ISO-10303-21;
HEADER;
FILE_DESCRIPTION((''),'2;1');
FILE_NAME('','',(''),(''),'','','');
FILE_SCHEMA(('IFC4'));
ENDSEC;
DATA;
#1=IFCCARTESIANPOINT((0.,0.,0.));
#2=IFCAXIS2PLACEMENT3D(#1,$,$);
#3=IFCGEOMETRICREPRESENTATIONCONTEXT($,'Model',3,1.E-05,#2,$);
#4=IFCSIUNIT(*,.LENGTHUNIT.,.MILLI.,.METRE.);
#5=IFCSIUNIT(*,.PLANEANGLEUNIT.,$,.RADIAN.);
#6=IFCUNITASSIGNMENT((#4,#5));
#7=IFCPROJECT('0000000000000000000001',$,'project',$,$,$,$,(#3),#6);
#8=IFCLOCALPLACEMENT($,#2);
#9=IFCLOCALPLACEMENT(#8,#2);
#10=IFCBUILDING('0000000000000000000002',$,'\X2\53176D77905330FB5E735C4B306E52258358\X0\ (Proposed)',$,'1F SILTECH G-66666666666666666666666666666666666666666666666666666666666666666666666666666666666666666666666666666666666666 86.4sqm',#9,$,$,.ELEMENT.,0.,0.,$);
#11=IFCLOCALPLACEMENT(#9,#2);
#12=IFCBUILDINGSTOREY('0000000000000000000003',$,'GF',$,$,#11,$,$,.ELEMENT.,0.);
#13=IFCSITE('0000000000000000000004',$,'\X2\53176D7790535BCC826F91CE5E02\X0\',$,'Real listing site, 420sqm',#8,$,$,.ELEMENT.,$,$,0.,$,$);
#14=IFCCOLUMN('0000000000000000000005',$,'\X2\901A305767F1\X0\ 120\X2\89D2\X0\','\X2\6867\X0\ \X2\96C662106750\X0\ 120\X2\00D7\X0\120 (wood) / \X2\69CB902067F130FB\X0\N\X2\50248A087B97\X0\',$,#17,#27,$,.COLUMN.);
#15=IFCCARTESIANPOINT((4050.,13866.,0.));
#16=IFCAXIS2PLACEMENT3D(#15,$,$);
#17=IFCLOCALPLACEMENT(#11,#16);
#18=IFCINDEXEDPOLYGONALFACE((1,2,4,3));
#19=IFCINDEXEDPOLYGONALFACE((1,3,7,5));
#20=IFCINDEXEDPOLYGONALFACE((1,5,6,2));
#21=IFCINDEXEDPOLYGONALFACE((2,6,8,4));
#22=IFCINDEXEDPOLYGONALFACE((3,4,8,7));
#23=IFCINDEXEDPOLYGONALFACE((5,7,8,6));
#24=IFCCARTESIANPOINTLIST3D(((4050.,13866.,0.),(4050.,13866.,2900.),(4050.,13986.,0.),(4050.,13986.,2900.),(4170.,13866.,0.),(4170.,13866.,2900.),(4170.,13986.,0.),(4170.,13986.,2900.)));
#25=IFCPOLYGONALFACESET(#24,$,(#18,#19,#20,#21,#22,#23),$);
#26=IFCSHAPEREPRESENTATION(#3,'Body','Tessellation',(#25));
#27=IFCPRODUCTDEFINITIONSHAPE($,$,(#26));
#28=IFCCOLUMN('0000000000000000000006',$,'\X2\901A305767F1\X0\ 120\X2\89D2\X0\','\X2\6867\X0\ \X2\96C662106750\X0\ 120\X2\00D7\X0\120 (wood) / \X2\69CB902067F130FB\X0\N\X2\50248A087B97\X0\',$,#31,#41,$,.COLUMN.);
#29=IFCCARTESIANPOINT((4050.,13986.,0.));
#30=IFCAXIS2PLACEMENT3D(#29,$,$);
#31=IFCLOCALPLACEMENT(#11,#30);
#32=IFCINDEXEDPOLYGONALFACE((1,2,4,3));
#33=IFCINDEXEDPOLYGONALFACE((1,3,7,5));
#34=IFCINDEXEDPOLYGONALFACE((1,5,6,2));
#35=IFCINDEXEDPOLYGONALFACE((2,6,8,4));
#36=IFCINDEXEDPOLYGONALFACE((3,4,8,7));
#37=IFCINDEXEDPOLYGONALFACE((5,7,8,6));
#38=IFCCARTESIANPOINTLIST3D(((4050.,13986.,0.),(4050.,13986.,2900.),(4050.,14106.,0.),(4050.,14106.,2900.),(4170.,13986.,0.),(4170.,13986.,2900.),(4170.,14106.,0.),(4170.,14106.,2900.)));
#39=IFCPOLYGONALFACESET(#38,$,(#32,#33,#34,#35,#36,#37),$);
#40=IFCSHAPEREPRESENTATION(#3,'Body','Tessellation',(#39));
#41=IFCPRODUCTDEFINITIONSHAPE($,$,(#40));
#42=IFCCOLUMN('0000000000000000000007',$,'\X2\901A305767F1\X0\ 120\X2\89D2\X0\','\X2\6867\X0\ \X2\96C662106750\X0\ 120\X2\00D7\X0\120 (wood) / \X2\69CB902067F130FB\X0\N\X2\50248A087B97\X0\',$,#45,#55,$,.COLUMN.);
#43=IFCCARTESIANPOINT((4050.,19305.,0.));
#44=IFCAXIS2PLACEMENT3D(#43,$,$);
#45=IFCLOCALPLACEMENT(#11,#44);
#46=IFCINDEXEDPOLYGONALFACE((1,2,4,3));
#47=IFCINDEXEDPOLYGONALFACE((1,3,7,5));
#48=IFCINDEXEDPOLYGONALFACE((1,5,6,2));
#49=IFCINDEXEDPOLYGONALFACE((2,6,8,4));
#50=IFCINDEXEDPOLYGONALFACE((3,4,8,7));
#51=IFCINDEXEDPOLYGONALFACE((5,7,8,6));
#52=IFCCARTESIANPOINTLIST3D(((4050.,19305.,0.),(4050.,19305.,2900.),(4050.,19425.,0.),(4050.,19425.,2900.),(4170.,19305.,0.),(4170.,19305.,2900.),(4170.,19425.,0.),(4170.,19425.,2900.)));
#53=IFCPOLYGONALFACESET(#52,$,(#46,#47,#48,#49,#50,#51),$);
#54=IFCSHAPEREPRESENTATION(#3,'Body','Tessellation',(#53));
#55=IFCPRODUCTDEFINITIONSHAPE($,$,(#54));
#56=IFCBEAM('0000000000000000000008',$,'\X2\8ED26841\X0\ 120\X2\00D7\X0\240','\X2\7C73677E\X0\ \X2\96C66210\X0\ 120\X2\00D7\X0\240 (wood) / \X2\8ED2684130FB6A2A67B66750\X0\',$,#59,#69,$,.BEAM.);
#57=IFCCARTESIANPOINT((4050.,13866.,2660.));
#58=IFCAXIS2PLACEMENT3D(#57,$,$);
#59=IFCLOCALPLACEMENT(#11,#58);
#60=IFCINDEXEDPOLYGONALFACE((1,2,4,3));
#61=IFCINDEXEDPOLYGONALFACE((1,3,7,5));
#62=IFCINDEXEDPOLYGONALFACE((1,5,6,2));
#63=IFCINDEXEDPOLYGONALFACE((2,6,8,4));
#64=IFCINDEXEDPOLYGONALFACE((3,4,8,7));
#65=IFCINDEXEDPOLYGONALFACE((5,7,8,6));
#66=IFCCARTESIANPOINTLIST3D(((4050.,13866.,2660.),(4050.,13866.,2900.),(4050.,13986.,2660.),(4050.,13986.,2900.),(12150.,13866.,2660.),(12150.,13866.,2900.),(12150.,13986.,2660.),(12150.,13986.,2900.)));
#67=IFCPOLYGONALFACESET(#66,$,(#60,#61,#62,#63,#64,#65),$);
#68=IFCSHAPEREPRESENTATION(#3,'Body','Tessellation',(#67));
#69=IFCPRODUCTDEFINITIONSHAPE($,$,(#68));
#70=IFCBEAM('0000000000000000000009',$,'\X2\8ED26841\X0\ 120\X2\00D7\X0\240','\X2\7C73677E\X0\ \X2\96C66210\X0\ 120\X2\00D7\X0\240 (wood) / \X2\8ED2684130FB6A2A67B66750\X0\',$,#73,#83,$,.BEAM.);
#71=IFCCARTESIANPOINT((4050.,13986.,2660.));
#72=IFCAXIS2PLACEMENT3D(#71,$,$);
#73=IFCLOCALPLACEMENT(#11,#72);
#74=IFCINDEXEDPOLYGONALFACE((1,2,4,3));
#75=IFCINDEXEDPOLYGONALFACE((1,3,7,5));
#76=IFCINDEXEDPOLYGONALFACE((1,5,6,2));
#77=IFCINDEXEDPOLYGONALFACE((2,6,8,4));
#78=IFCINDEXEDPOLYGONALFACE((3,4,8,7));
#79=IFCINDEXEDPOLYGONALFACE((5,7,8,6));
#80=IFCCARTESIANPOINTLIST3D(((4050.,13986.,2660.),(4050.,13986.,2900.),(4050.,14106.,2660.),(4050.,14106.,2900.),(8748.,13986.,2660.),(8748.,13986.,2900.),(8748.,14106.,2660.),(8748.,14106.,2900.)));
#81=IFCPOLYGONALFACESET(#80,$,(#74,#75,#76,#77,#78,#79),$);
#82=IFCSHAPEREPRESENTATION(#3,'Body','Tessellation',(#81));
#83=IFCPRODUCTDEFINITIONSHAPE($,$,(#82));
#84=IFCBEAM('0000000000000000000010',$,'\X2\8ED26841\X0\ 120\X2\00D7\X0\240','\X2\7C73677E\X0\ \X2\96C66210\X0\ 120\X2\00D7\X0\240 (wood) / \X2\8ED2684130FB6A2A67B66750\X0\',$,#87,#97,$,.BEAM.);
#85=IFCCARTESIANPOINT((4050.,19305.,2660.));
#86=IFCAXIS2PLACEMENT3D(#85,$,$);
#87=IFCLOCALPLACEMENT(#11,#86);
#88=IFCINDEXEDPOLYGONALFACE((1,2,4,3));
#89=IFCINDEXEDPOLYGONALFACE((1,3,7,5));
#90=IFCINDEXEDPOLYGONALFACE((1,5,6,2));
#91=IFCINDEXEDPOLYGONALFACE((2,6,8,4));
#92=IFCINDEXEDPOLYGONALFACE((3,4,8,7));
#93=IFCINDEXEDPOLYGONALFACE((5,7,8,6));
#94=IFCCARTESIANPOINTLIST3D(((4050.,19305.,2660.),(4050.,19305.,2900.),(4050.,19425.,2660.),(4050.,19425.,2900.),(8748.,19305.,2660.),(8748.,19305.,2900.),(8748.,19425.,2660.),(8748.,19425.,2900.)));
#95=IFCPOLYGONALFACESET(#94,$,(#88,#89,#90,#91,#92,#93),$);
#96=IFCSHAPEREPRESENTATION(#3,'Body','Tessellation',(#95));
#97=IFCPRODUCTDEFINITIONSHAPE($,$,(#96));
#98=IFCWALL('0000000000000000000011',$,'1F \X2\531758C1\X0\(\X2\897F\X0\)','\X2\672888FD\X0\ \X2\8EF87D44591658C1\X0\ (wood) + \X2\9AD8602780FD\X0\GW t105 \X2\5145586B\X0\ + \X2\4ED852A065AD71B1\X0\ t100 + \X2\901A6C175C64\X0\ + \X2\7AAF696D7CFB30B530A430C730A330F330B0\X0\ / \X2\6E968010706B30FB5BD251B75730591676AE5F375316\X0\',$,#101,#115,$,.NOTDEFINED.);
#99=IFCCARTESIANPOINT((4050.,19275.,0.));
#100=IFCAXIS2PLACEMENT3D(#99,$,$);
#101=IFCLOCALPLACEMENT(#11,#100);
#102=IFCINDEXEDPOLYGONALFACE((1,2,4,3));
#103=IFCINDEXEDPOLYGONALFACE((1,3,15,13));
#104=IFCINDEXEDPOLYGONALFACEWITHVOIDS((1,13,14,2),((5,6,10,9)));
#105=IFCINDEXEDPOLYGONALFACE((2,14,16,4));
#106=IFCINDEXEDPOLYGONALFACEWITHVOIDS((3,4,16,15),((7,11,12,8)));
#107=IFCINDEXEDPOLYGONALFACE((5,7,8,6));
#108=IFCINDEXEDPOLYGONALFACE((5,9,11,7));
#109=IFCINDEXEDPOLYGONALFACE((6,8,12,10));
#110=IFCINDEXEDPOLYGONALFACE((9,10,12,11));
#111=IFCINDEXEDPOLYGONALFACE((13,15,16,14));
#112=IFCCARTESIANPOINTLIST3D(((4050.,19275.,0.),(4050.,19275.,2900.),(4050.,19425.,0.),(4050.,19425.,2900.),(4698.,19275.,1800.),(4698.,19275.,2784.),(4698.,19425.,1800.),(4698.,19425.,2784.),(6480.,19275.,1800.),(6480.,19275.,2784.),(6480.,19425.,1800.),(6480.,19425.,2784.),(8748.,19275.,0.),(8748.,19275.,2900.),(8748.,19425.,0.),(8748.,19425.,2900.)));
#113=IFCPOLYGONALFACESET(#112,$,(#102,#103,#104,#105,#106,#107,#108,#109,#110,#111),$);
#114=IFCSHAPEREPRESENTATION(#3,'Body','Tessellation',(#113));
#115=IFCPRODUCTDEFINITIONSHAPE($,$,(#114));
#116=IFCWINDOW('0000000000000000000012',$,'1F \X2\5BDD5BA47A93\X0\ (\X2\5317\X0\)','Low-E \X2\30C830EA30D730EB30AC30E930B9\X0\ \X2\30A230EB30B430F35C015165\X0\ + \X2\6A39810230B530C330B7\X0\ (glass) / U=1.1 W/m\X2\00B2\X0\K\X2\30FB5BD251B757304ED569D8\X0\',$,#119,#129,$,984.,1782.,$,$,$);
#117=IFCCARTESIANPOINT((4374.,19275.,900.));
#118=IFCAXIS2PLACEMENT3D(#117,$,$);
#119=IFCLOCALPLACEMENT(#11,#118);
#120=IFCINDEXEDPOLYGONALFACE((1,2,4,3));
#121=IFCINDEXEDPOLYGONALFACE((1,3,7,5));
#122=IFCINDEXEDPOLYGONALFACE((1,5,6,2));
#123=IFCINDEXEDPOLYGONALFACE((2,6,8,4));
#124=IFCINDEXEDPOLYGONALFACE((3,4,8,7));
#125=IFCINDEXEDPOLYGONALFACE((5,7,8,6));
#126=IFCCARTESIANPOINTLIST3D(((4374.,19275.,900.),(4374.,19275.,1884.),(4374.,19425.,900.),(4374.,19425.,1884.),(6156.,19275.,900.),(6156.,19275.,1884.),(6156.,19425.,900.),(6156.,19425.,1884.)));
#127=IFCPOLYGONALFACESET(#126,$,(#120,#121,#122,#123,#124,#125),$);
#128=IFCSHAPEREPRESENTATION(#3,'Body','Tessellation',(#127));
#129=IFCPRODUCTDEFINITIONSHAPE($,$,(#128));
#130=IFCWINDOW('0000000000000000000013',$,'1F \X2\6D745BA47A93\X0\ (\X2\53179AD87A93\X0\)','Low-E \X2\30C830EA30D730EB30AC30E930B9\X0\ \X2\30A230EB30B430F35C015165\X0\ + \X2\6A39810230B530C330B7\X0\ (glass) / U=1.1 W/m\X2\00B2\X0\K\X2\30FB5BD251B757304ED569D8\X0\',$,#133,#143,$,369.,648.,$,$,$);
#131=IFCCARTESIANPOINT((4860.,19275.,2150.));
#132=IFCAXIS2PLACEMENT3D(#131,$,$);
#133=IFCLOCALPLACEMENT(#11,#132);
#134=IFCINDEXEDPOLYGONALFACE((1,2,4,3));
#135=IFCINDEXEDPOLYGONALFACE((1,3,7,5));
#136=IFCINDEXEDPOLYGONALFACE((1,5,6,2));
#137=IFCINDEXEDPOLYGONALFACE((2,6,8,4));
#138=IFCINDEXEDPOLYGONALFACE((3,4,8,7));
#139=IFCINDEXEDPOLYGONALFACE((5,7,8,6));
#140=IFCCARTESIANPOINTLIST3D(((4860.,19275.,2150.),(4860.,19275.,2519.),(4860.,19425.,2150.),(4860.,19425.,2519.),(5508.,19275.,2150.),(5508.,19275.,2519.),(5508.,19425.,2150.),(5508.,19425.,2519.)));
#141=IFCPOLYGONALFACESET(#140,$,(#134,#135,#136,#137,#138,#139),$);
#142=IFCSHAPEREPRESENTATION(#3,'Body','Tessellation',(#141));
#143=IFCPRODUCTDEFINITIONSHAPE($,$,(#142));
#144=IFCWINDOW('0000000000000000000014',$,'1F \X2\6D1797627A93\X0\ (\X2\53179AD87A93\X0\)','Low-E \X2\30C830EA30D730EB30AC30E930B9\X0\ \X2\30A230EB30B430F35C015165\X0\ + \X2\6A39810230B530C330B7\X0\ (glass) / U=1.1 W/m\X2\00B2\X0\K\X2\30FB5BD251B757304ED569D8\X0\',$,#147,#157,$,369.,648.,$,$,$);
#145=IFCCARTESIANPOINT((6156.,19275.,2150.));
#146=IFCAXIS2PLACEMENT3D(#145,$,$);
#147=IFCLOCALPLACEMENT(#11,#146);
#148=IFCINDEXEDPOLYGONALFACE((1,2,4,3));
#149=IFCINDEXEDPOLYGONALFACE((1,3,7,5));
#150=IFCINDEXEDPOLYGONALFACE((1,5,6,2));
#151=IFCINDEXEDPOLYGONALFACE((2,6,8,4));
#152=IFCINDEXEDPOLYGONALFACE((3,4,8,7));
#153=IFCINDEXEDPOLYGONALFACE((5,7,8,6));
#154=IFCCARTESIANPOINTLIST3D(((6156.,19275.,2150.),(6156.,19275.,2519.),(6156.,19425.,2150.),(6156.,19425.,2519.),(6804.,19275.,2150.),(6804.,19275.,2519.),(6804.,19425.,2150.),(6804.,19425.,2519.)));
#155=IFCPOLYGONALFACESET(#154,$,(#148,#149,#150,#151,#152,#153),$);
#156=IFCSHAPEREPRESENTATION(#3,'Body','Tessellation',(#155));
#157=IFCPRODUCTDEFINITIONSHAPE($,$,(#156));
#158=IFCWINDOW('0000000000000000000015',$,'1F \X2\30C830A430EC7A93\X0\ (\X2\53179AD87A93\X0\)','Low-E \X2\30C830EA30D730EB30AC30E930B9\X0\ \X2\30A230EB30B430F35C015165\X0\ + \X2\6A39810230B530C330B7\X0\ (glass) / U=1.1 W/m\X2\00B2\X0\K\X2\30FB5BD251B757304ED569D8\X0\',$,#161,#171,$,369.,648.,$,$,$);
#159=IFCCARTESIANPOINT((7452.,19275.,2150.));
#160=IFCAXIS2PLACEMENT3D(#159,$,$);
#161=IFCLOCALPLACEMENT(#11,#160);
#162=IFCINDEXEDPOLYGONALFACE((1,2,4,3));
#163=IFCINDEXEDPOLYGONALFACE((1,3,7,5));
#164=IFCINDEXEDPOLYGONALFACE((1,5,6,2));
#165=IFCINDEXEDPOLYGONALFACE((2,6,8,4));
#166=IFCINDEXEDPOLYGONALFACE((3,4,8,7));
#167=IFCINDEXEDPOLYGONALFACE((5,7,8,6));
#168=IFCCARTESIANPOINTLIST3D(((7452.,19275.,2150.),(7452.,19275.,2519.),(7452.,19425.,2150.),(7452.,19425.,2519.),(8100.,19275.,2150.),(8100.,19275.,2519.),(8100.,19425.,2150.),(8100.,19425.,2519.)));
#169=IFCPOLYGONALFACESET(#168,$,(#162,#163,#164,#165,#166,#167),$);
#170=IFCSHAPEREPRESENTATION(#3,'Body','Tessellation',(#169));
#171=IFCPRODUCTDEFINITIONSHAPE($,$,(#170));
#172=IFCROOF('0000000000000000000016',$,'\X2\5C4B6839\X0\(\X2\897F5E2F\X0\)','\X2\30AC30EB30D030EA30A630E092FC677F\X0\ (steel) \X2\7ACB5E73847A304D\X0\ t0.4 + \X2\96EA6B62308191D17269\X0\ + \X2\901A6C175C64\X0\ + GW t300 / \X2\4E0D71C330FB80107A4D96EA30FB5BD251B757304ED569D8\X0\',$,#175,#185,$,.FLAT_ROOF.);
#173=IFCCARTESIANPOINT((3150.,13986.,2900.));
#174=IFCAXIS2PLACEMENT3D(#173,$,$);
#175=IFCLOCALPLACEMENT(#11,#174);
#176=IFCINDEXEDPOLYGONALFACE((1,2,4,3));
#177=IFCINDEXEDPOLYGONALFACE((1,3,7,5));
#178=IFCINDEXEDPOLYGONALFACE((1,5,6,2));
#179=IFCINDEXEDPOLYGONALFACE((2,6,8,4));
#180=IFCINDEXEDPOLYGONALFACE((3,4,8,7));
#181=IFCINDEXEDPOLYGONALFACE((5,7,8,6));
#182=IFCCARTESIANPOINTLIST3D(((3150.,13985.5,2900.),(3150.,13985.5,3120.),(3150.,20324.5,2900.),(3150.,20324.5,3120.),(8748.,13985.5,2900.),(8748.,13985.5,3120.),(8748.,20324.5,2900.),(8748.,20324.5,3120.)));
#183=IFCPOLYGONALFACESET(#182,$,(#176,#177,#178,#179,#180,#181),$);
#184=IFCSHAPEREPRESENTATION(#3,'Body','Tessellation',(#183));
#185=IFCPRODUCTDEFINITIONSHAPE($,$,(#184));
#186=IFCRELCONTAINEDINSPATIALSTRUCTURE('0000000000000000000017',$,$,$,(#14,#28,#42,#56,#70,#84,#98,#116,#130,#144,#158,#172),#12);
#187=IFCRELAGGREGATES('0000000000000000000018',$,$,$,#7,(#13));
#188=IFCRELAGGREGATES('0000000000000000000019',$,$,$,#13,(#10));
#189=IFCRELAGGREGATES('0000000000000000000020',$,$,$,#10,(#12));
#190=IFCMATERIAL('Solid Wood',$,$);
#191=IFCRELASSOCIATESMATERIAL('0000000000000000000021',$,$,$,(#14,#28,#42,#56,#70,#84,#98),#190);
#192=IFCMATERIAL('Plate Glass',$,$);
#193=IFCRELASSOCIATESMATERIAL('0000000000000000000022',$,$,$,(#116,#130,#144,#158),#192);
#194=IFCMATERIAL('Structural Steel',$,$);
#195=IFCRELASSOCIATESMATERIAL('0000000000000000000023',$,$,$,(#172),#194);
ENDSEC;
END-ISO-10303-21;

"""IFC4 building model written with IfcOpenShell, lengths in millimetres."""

from ifc_helpers import new_model, si_unit, frame, frame_2d, origin, place, context, project, spatial, rectangle, extrude, material, element, fill, save


model = new_model("IFC4")

# Units and contexts
model_context = context("Model", 3, precision=1e-05, world=origin())
ifc_project = project(units=[si_unit("LENGTHUNIT", "METRE", prefix="MILLI"), si_unit("PLANEANGLEUNIT", "RADIAN")], contexts=[model_context])

# Site, building, storey
site_placement = place(None, origin())
site = spatial("IfcSite", under=ifc_project, at=site_placement, Name="北海道富良野市", ObjectType="Real listing site, 420sqm", CompositionType="ELEMENT", RefElevation=0.0)
building_placement = place(site_placement, origin())
building = spatial("IfcBuilding", under=site, at=building_placement, Name="北海道・平屋の別荘 (Proposed)", ObjectType="1F SILTECH G-66666666666666666666666666666666666666666666666666666666666666666666666666666666666666666666666666666666666666 86.4sqm", CompositionType="ELEMENT", ElevationOfRefHeight=0.0, ElevationOfTerrain=0.0)
storey_placement = place(building_placement, origin())
storey = spatial("IfcBuildingStorey", under=building, at=storey_placement, Name="GF", CompositionType="ELEMENT", Elevation=0.0)

# Columns
ifc_material_1 = material(Name="Solid Wood")
column_1_placement = place(storey_placement, frame((4050.0, 13866.0, 0.0)))
element("IfcColumn", 1, at=column_1_placement, inside=storey, material=ifc_material_1, Name="通し柱 120角", Description="桧 集成材 120×120 (wood) / 構造柱・N値計算", PredefinedType="COLUMN", context=model_context, shape_type="SweptSolid", body=[
    extrude(rectangle(XDim=120.0, YDim=120.0, at=frame_2d((60.0, 60.0))), frame((4050.0, 13866.0, 0.0)), (0.0, 0.0, 1.0), 2900.0),
])
column_2_placement = place(storey_placement, frame((4050.0, 13986.0, 0.0)))
element("IfcColumn", 2, at=column_2_placement, inside=storey, material=ifc_material_1, Name="通し柱 120角", Description="桧 集成材 120×120 (wood) / 構造柱・N値計算", PredefinedType="COLUMN", context=model_context, shape_type="SweptSolid", body=[
    extrude(rectangle(XDim=120.0, YDim=120.0, at=frame_2d((60.0, 60.0))), frame((4050.0, 13986.0, 0.0)), (0.0, 0.0, 1.0), 2900.0),
])
column_3_placement = place(storey_placement, frame((4050.0, 19305.0, 0.0)))
element("IfcColumn", 3, at=column_3_placement, inside=storey, material=ifc_material_1, Name="通し柱 120角", Description="桧 集成材 120×120 (wood) / 構造柱・N値計算", PredefinedType="COLUMN", context=model_context, shape_type="SweptSolid", body=[
    extrude(rectangle(XDim=120.0, YDim=120.0, at=frame_2d((60.0, 60.0))), frame((4050.0, 19305.0, 0.0)), (0.0, 0.0, 1.0), 2900.0),
])

# Beams
beam_1_placement = place(storey_placement, frame((4050.0, 13866.0, 2660.0)))
element("IfcBeam", 4, at=beam_1_placement, inside=storey, material=ifc_material_1, Name="軒桁 120×240", Description="米松 集成 120×240 (wood) / 軒桁・横架材", PredefinedType="BEAM", context=model_context, shape_type="SweptSolid", body=[
    extrude(rectangle(XDim=8100.0, YDim=120.0, at=frame_2d((4050.0, 60.0))), frame((4050.0, 13866.0, 2660.0)), (0.0, 0.0, 1.0), 240.0),
])
beam_2_placement = place(storey_placement, frame((4050.0, 13986.0, 2660.0)))
element("IfcBeam", 5, at=beam_2_placement, inside=storey, material=ifc_material_1, Name="軒桁 120×240", Description="米松 集成 120×240 (wood) / 軒桁・横架材", PredefinedType="BEAM", context=model_context, shape_type="SweptSolid", body=[
    extrude(rectangle(XDim=4698.0, YDim=120.0, at=frame_2d((2349.0, 60.0))), frame((4050.0, 13986.0, 2660.0)), (0.0, 0.0, 1.0), 240.0),
])
beam_3_placement = place(storey_placement, frame((4050.0, 19305.0, 2660.0)))
element("IfcBeam", 6, at=beam_3_placement, inside=storey, material=ifc_material_1, Name="軒桁 120×240", Description="米松 集成 120×240 (wood) / 軒桁・横架材", PredefinedType="BEAM", context=model_context, shape_type="SweptSolid", body=[
    extrude(rectangle(XDim=4698.0, YDim=120.0, at=frame_2d((2349.0, 60.0))), frame((4050.0, 19305.0, 2660.0)), (0.0, 0.0, 1.0), 240.0),
])

# Wall, openings, windows
wall_1_placement = place(storey_placement, frame((4050.0, 19275.0, 0.0)))
wall_1 = element("IfcWall", 7, at=wall_1_placement, inside=storey, material=ifc_material_1, Name="1F 北壁(西)", Description="木製 軸組外壁 (wood) + 高性能GW t105 充填 + 付加断熱 t100 + 通気層 + 窯業系サイディング / 準耐火・寒冷地外皮強化", PredefinedType="NOTDEFINED", context=model_context, shape_type="SweptSolid", body=[
    extrude(rectangle(XDim=4698.0, YDim=150.0, at=frame_2d((2349.0, 75.0))), frame((4050.0, 19275.0, 0.0)), (0.0, 0.0, 1.0), 2900.0),
])
opening_1_placement = place(storey_placement, frame((4374.0, 19275.0, 900.0)))
opening_1 = element("IfcOpeningElement", 8, at=opening_1_placement, cuts=wall_1, PredefinedType="NOTDEFINED", context=model_context, shape_type="SweptSolid", body=[
    extrude(rectangle(XDim=1782.0, YDim=150.0, at=frame_2d((891.0, 75.0))), frame((4374.0, 19275.0, 900.0)), (0.0, 0.0, 1.0), 984.0),
])
opening_2_placement = place(storey_placement, frame((4860.0, 19275.0, 2150.0)))
opening_2 = element("IfcOpeningElement", 9, at=opening_2_placement, cuts=wall_1, PredefinedType="NOTDEFINED", context=model_context, shape_type="SweptSolid", body=[
    extrude(rectangle(XDim=648.0, YDim=150.0, at=frame_2d((324.0, 75.0))), frame((4860.0, 19275.0, 2150.0)), (0.0, 0.0, 1.0), 369.0),
])
opening_3_placement = place(storey_placement, frame((6156.0, 19275.0, 2150.0)))
opening_3 = element("IfcOpeningElement", 10, at=opening_3_placement, cuts=wall_1, PredefinedType="NOTDEFINED", context=model_context, shape_type="SweptSolid", body=[
    extrude(rectangle(XDim=648.0, YDim=150.0, at=frame_2d((324.0, 75.0))), frame((6156.0, 19275.0, 2150.0)), (0.0, 0.0, 1.0), 369.0),
])
opening_4_placement = place(storey_placement, frame((7452.0, 19275.0, 2150.0)))
opening_4 = element("IfcOpeningElement", 11, at=opening_4_placement, cuts=wall_1, PredefinedType="NOTDEFINED", context=model_context, shape_type="SweptSolid", body=[
    extrude(rectangle(XDim=648.0, YDim=150.0, at=frame_2d((324.0, 75.0))), frame((7452.0, 19275.0, 2150.0)), (0.0, 0.0, 1.0), 369.0),
])
ifc_material_2 = material(Name="Plate Glass")
window_1_placement = place(storey_placement, frame((4374.0, 19275.0, 900.0)))
window_1 = element("IfcWindow", 12, at=window_1_placement, inside=storey, material=ifc_material_2, Name="1F 寝室窓 (北)", Description="Low-E トリプルガラス アルゴン封入 + 樹脂サッシ (glass) / U=1.1 W/m²K・寒冷地仕様", OverallHeight=984.0, OverallWidth=1782.0, context=model_context, shape_type="SweptSolid", body=[
    extrude(rectangle(XDim=1782.0, YDim=150.0, at=frame_2d((891.0, 75.0))), frame((4374.0, 19275.0, 900.0)), (0.0, 0.0, 1.0), 984.0),
])
fill(opening_1, window_1)
window_2_placement = place(storey_placement, frame((4860.0, 19275.0, 2150.0)))
window_2 = element("IfcWindow", 13, at=window_2_placement, inside=storey, material=ifc_material_2, Name="1F 浴室窓 (北高窓)", Description="Low-E トリプルガラス アルゴン封入 + 樹脂サッシ (glass) / U=1.1 W/m²K・寒冷地仕様", OverallHeight=369.0, OverallWidth=648.0, context=model_context, shape_type="SweptSolid", body=[
    extrude(rectangle(XDim=648.0, YDim=150.0, at=frame_2d((324.0, 75.0))), frame((4860.0, 19275.0, 2150.0)), (0.0, 0.0, 1.0), 369.0),
])
fill(opening_2, window_2)
window_3_placement = place(storey_placement, frame((6156.0, 19275.0, 2150.0)))
window_3 = element("IfcWindow", 14, at=window_3_placement, inside=storey, material=ifc_material_2, Name="1F 洗面窓 (北高窓)", Description="Low-E トリプルガラス アルゴン封入 + 樹脂サッシ (glass) / U=1.1 W/m²K・寒冷地仕様", OverallHeight=369.0, OverallWidth=648.0, context=model_context, shape_type="SweptSolid", body=[
    extrude(rectangle(XDim=648.0, YDim=150.0, at=frame_2d((324.0, 75.0))), frame((6156.0, 19275.0, 2150.0)), (0.0, 0.0, 1.0), 369.0),
])
fill(opening_3, window_3)
window_4_placement = place(storey_placement, frame((7452.0, 19275.0, 2150.0)))
window_4 = element("IfcWindow", 15, at=window_4_placement, inside=storey, material=ifc_material_2, Name="1F トイレ窓 (北高窓)", Description="Low-E トリプルガラス アルゴン封入 + 樹脂サッシ (glass) / U=1.1 W/m²K・寒冷地仕様", OverallHeight=369.0, OverallWidth=648.0, context=model_context, shape_type="SweptSolid", body=[
    extrude(rectangle(XDim=648.0, YDim=150.0, at=frame_2d((324.0, 75.0))), frame((7452.0, 19275.0, 2150.0)), (0.0, 0.0, 1.0), 369.0),
])
fill(opening_4, window_4)

# Roof
ifc_material_3 = material(Name="Structural Steel")
roof_placement = place(storey_placement, frame((3150.0, 13986.0, 2900.0)))
element("IfcRoof", 16, at=roof_placement, inside=storey, material=ifc_material_3, Name="屋根(西帯)", Description="ガルバリウム鋼板 (steel) 立平葺き t0.4 + 雪止め金物 + 通気層 + GW t300 / 不燃・耐積雪・寒冷地仕様", PredefinedType="FLAT_ROOF", context=model_context, shape_type="SweptSolid", body=[
    extrude(rectangle(XDim=5598.0, YDim=6339.0, at=frame_2d((2799.0, 3169.0))), frame((3150.0, 13986.0, 2900.0)), (0.0, 0.0, 1.0), 220.0),
])

save(model, "model.ifc")
